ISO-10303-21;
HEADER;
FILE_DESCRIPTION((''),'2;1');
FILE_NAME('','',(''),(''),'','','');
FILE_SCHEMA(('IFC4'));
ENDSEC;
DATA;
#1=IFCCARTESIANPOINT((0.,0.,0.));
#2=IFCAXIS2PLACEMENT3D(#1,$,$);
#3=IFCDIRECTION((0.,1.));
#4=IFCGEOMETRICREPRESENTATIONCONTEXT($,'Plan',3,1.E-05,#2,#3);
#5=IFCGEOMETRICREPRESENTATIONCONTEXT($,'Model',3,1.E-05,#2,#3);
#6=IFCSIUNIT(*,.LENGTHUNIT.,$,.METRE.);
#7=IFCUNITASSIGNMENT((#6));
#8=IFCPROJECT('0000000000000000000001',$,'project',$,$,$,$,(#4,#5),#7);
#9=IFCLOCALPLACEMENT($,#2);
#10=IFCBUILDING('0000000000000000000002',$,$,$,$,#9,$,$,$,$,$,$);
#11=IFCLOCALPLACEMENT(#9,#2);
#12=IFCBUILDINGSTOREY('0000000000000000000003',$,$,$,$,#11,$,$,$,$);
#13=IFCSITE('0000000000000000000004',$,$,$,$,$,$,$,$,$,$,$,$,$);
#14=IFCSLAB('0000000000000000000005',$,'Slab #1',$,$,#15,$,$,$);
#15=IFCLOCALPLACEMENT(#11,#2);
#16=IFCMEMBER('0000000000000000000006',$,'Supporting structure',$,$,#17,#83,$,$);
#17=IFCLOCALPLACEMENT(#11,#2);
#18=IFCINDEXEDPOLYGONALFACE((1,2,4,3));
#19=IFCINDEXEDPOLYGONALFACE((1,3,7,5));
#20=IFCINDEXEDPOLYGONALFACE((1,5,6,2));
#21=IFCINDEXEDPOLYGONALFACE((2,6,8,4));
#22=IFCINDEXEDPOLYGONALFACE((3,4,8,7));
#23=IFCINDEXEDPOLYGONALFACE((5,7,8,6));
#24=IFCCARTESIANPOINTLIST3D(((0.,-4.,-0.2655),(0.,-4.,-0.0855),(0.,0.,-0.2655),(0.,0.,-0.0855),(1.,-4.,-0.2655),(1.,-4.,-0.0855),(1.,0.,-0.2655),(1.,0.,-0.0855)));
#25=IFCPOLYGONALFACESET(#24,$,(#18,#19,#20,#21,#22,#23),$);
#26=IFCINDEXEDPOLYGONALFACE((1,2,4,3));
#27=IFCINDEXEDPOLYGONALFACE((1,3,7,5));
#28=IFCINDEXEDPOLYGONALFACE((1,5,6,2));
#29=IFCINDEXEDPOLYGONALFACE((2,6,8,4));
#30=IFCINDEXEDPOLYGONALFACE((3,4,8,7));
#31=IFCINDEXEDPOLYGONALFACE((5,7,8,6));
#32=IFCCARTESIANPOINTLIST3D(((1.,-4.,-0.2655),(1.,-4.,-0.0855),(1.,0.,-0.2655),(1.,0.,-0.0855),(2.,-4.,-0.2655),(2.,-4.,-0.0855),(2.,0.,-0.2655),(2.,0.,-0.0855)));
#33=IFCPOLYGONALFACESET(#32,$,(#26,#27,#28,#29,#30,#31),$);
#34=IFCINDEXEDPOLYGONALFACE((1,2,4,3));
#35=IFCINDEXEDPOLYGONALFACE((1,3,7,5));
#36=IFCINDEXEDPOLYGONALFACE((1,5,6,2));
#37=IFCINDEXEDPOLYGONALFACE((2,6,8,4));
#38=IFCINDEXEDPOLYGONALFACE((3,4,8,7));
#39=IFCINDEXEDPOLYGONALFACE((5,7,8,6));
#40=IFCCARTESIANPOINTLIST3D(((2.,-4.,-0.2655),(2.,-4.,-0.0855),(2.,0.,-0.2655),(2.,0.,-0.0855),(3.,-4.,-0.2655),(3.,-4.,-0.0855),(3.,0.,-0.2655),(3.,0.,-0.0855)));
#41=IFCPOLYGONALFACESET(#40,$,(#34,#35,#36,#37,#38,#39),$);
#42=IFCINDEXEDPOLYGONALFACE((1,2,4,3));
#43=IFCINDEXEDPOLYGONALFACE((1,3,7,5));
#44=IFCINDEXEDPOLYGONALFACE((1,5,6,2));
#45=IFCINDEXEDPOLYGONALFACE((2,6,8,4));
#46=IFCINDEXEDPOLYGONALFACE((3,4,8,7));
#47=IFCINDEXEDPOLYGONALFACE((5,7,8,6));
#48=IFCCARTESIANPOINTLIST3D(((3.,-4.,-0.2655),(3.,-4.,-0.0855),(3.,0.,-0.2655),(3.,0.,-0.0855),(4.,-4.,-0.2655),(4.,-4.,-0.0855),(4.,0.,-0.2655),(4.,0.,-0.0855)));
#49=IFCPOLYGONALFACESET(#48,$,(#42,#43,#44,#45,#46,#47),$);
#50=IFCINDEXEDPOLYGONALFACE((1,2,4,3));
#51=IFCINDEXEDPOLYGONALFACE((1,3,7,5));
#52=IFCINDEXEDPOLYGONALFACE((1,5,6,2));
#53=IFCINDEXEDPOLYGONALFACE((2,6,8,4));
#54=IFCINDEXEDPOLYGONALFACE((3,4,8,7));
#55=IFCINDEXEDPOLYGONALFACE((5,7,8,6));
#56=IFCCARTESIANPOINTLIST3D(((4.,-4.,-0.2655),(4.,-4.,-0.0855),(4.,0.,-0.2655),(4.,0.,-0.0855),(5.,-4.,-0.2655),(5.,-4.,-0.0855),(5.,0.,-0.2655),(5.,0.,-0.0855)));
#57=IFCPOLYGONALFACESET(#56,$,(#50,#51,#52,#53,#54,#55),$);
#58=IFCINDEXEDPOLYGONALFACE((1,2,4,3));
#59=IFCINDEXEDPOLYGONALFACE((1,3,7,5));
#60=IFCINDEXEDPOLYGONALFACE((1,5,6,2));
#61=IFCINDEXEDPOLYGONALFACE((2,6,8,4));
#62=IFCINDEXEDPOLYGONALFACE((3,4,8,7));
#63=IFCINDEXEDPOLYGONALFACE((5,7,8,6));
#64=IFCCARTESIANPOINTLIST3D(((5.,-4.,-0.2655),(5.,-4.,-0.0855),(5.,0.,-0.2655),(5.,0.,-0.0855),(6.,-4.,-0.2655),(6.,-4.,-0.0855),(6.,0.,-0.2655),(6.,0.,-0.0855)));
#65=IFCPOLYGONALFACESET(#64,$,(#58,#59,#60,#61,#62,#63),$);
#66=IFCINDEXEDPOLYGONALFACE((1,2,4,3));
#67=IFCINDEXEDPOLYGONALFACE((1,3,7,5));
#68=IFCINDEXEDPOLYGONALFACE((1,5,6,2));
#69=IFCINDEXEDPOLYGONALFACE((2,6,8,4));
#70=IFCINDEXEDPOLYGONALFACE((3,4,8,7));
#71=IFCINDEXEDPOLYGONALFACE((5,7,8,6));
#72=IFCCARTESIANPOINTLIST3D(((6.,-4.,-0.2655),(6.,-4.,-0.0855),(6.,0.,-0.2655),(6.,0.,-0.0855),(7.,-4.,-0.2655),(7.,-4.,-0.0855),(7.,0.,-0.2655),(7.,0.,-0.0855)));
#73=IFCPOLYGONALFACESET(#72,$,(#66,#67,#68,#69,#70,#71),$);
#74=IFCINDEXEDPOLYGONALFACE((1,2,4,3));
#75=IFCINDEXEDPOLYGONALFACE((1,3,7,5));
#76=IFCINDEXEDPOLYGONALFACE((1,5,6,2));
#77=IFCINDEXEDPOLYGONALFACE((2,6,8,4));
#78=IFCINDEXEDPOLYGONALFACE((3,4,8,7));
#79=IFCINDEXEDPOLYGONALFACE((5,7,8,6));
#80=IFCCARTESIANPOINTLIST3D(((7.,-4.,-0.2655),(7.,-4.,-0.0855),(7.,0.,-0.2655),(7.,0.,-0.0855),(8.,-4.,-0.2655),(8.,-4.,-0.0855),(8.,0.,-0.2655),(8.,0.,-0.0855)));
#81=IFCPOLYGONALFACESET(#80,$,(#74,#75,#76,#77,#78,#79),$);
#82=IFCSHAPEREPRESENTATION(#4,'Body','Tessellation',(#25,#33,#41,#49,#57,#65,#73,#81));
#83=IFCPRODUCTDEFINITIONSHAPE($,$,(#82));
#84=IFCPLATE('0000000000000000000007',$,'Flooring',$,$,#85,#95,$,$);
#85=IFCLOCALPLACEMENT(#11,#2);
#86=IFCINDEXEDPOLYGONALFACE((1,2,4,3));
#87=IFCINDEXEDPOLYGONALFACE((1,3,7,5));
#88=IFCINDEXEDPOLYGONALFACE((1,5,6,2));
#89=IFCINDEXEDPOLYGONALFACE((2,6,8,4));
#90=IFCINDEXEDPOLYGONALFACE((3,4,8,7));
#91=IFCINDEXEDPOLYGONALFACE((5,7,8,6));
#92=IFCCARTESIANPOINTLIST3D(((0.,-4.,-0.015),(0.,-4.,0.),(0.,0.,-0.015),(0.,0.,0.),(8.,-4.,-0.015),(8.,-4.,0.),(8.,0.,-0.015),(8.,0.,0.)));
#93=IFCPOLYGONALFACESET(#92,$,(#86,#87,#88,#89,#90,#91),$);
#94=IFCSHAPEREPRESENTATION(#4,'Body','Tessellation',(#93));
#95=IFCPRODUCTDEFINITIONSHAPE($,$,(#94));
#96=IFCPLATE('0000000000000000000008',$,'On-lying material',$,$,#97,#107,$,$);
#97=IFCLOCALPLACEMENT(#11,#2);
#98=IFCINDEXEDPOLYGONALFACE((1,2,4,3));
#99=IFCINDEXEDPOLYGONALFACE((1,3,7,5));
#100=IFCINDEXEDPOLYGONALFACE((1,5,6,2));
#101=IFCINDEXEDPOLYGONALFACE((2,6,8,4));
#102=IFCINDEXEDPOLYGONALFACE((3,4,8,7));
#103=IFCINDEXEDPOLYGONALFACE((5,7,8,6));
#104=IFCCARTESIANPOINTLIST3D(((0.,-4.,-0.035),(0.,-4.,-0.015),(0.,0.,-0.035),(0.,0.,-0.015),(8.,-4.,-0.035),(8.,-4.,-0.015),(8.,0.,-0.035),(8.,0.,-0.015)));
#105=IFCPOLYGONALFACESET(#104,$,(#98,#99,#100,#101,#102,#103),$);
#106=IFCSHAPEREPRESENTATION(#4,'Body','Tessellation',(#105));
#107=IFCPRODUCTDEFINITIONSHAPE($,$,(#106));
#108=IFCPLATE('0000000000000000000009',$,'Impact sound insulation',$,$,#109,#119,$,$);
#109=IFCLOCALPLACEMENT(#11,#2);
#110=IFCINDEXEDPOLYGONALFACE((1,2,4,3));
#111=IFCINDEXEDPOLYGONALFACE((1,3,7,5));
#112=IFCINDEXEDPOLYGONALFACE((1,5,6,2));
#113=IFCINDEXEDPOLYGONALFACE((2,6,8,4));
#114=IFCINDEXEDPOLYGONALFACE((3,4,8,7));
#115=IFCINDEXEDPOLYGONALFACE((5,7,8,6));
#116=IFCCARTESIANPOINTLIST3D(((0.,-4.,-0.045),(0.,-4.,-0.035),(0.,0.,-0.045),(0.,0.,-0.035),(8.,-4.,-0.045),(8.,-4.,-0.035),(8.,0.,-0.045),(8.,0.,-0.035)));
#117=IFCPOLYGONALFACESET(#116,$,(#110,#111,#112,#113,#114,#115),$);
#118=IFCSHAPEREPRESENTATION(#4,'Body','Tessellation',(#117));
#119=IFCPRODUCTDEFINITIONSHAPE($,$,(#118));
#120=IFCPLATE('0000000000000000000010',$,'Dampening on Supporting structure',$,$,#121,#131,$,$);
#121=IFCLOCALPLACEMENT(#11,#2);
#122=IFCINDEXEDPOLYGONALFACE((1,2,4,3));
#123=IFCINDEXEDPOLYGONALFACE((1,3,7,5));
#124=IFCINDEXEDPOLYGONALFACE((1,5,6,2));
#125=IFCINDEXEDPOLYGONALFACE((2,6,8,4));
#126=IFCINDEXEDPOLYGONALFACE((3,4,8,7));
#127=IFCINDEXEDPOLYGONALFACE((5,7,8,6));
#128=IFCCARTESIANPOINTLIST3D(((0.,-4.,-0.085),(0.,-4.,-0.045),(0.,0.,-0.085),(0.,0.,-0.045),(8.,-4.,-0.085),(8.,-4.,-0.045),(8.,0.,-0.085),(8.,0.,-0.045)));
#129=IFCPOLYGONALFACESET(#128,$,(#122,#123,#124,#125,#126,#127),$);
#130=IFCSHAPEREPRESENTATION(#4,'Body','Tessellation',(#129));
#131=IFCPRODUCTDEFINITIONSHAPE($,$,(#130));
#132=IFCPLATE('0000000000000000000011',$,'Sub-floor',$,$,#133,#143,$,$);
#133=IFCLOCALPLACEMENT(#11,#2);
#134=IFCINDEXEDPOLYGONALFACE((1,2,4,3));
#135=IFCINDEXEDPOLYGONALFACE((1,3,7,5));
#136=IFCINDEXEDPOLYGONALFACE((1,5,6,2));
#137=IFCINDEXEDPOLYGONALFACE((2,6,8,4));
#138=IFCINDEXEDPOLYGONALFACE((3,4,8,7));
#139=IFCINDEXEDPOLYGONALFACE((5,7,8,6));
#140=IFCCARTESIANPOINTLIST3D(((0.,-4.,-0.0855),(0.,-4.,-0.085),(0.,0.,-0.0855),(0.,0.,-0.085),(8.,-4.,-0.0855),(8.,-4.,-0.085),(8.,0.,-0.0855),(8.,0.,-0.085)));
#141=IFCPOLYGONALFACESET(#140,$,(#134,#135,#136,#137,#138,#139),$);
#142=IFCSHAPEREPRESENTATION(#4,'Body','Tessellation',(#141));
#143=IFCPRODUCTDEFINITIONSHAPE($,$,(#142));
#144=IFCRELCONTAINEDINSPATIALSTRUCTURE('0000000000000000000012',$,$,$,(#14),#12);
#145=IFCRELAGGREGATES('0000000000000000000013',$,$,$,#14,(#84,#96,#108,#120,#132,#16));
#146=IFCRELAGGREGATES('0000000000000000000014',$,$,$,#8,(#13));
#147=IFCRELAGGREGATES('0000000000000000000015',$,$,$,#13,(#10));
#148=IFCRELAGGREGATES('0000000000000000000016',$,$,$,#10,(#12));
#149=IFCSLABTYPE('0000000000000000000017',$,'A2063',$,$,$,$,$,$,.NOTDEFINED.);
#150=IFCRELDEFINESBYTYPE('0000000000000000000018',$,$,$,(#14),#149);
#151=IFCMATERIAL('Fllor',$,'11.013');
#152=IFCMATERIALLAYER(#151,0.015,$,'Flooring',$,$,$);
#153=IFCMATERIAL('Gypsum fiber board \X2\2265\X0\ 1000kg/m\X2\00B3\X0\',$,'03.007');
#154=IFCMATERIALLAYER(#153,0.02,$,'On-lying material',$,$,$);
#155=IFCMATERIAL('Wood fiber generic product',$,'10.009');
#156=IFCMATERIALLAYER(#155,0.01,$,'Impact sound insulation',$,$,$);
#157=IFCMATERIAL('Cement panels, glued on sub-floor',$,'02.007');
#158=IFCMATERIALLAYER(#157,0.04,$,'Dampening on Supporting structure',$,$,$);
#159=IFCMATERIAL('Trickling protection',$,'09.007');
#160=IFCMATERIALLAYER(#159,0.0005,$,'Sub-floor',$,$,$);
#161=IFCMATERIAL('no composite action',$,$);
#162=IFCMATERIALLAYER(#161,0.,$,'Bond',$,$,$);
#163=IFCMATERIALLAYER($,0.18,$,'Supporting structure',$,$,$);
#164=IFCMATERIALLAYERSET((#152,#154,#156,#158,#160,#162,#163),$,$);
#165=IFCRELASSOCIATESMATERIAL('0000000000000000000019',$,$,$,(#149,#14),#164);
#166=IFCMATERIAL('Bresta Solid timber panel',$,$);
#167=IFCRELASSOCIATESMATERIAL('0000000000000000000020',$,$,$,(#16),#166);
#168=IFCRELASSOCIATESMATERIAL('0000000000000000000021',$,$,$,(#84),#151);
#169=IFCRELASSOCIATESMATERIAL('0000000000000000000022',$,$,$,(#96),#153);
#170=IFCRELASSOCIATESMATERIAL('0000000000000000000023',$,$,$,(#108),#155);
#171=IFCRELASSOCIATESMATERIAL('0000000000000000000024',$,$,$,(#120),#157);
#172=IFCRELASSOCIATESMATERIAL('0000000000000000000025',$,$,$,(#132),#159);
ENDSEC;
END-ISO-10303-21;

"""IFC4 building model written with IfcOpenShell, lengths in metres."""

from ifc_helpers import new_model, si_unit, direction, frame, frame_2d, origin, origin_with_axes, place, context, project, spatial, rectangle, extrude, material, layer, layer_set, type_object, element, aggregate, save


model = new_model("IFC4")

# Units and contexts
plan_context = context("Plan", 3, precision=1e-05, world=origin(), true_north=direction((0.0, 1.0)))
model_context = context("Model", 3, precision=1e-05, world=origin(), true_north=direction((0.0, 1.0)))
ifc_project = project(units=[si_unit("LENGTHUNIT", "METRE")], contexts=[plan_context, model_context])

# Site, building, storey
site = spatial("IfcSite", under=ifc_project)
building_placement = place(None, origin())
building = spatial("IfcBuilding", under=site, at=building_placement)
storey_placement = place(building_placement, origin())
storey = spatial("IfcBuildingStorey", under=building, at=storey_placement)

# Slab, member, plates
ifc_material_1 = material(Name="Fllor", Category="11.013")
ifc_layer_1 = layer(ifc_material_1, 0.015, Name="Flooring")
ifc_material_2 = material(Name="Gypsum fiber board ≥ 1000kg/m³", Category="03.007")
ifc_layer_2 = layer(ifc_material_2, 0.02, Name="On-lying material")
ifc_material_3 = material(Name="Wood fiber generic product", Category="10.009")
ifc_layer_3 = layer(ifc_material_3, 0.01, Name="Impact sound insulation")
ifc_material_4 = material(Name="Cement panels, glued on sub-floor", Category="02.007")
ifc_layer_4 = layer(ifc_material_4, 0.04, Name="Dampening on Supporting structure")
ifc_material_5 = material(Name="Trickling protection", Category="09.007")
ifc_layer_5 = layer(ifc_material_5, 0.0005, Name="Sub-floor")
ifc_material_6 = material(Name="no composite action")
ifc_layer_6 = layer(ifc_material_6, 0.0, Name="Bond")
ifc_layer_7 = layer(None, 0.18, Name="Supporting structure")
ifc_layer_set = layer_set([ifc_layer_1, ifc_layer_2, ifc_layer_3, ifc_layer_4, ifc_layer_5, ifc_layer_6, ifc_layer_7])
slab_type = type_object("IfcSlabType", Name="A2063", PredefinedType="NOTDEFINED", material=ifc_layer_set)
slab_placement = place(None, frame((0.0, 0.0, 0.0), z_axis=(0.0, 0.0, -1.0), x_axis=(1.0, 0.0, 0.0)))
slab = element("IfcSlab", 1, at=slab_placement, inside=storey, type_object=slab_type, material=ifc_layer_set, Name="Slab #1")
ifc_material_7 = material(Name="Bresta Solid timber panel")
member_placement = place(slab_placement, origin())
member = element("IfcMember", 2, at=member_placement, material=ifc_material_7, Name="Supporting structure", context=plan_context, shape_type="SweptSolid", body=[
    extrude(rectangle(XDim=1.0, YDim=0.18, at=frame_2d((0.5, 0.09), x_axis=(1.0, 0.0))), frame((0.0, 4.0, 0.0855), z_axis=(0.0, -1.0, 0.0), x_axis=(1.0, 0.0, 0.0)), (0.0, 0.0, 1.0), 4.0),
    extrude(rectangle(XDim=1.0, YDim=0.18, at=frame_2d((0.5, 0.09), x_axis=(1.0, 0.0))), frame((1.0, 4.0, 0.0855), z_axis=(0.0, -1.0, 0.0), x_axis=(1.0, 0.0, 0.0)), (0.0, 0.0, 1.0), 4.0),
    extrude(rectangle(XDim=1.0, YDim=0.18, at=frame_2d((0.5, 0.09), x_axis=(1.0, 0.0))), frame((2.0, 4.0, 0.0855), z_axis=(0.0, -1.0, 0.0), x_axis=(1.0, 0.0, 0.0)), (0.0, 0.0, 1.0), 4.0),
    extrude(rectangle(XDim=1.0, YDim=0.18, at=frame_2d((0.5, 0.09), x_axis=(1.0, 0.0))), frame((3.0, 4.0, 0.0855), z_axis=(0.0, -1.0, 0.0), x_axis=(1.0, 0.0, 0.0)), (0.0, 0.0, 1.0), 4.0),
    extrude(rectangle(XDim=1.0, YDim=0.18, at=frame_2d((0.5, 0.09), x_axis=(1.0, 0.0))), frame((4.0, 4.0, 0.0855), z_axis=(0.0, -1.0, 0.0), x_axis=(1.0, 0.0, 0.0)), (0.0, 0.0, 1.0), 4.0),
    extrude(rectangle(XDim=1.0, YDim=0.18, at=frame_2d((0.5, 0.09), x_axis=(1.0, 0.0))), frame((5.0, 4.0, 0.0855), z_axis=(0.0, -1.0, 0.0), x_axis=(1.0, 0.0, 0.0)), (0.0, 0.0, 1.0), 4.0),
    extrude(rectangle(XDim=1.0, YDim=0.18, at=frame_2d((0.5, 0.09), x_axis=(1.0, 0.0))), frame((6.0, 4.0, 0.0855), z_axis=(0.0, -1.0, 0.0), x_axis=(1.0, 0.0, 0.0)), (0.0, 0.0, 1.0), 4.0),
    extrude(rectangle(XDim=1.0, YDim=0.18, at=frame_2d((0.5, 0.09), x_axis=(1.0, 0.0))), frame((7.0, 4.0, 0.0855), z_axis=(0.0, -1.0, 0.0), x_axis=(1.0, 0.0, 0.0)), (0.0, 0.0, 1.0), 4.0),
])
plate_1_placement = place(slab_placement, origin())
plate_1 = element("IfcPlate", 3, at=plate_1_placement, material=ifc_material_1, Name="Flooring", context=plan_context, shape_type="SweptSolid", body=[
    extrude(rectangle(XDim=8.0, YDim=4.0, at=frame_2d((4.0, 2.0), x_axis=(1.0, 0.0))), origin_with_axes(), (0.0, 0.0, 1.0), 0.015),
])
plate_2_placement = place(slab_placement, origin())
plate_2 = element("IfcPlate", 4, at=plate_2_placement, material=ifc_material_2, Name="On-lying material", context=plan_context, shape_type="SweptSolid", body=[
    extrude(rectangle(XDim=8.0, YDim=4.0, at=frame_2d((4.0, 2.0), x_axis=(1.0, 0.0))), frame((0.0, 0.0, 0.015), z_axis=(0.0, 0.0, 1.0), x_axis=(1.0, 0.0, 0.0)), (0.0, 0.0, 1.0), 0.02),
])
plate_3_placement = place(slab_placement, origin())
plate_3 = element("IfcPlate", 5, at=plate_3_placement, material=ifc_material_3, Name="Impact sound insulation", context=plan_context, shape_type="SweptSolid", body=[
    extrude(rectangle(XDim=8.0, YDim=4.0, at=frame_2d((4.0, 2.0), x_axis=(1.0, 0.0))), frame((0.0, 0.0, 0.035), z_axis=(0.0, 0.0, 1.0), x_axis=(1.0, 0.0, 0.0)), (0.0, 0.0, 1.0), 0.01),
])
plate_4_placement = place(slab_placement, origin())
plate_4 = element("IfcPlate", 6, at=plate_4_placement, material=ifc_material_4, Name="Dampening on Supporting structure", context=plan_context, shape_type="SweptSolid", body=[
    extrude(rectangle(XDim=8.0, YDim=4.0, at=frame_2d((4.0, 2.0), x_axis=(1.0, 0.0))), frame((0.0, 0.0, 0.045), z_axis=(0.0, 0.0, 1.0), x_axis=(1.0, 0.0, 0.0)), (0.0, 0.0, 1.0), 0.04),
])
plate_5_placement = place(slab_placement, origin())
plate_5 = element("IfcPlate", 7, at=plate_5_placement, material=ifc_material_5, Name="Sub-floor", context=plan_context, shape_type="SweptSolid", body=[
    extrude(rectangle(XDim=8.0, YDim=4.0, at=frame_2d((4.0, 2.0), x_axis=(1.0, 0.0))), frame((0.0, 0.0, 0.085), z_axis=(0.0, 0.0, 1.0), x_axis=(1.0, 0.0, 0.0)), (0.0, 0.0, 1.0), 0.0005),
])
aggregate(slab, [plate_1, plate_2, plate_3, plate_4, plate_5, member])

save(model, "model.ifc")
